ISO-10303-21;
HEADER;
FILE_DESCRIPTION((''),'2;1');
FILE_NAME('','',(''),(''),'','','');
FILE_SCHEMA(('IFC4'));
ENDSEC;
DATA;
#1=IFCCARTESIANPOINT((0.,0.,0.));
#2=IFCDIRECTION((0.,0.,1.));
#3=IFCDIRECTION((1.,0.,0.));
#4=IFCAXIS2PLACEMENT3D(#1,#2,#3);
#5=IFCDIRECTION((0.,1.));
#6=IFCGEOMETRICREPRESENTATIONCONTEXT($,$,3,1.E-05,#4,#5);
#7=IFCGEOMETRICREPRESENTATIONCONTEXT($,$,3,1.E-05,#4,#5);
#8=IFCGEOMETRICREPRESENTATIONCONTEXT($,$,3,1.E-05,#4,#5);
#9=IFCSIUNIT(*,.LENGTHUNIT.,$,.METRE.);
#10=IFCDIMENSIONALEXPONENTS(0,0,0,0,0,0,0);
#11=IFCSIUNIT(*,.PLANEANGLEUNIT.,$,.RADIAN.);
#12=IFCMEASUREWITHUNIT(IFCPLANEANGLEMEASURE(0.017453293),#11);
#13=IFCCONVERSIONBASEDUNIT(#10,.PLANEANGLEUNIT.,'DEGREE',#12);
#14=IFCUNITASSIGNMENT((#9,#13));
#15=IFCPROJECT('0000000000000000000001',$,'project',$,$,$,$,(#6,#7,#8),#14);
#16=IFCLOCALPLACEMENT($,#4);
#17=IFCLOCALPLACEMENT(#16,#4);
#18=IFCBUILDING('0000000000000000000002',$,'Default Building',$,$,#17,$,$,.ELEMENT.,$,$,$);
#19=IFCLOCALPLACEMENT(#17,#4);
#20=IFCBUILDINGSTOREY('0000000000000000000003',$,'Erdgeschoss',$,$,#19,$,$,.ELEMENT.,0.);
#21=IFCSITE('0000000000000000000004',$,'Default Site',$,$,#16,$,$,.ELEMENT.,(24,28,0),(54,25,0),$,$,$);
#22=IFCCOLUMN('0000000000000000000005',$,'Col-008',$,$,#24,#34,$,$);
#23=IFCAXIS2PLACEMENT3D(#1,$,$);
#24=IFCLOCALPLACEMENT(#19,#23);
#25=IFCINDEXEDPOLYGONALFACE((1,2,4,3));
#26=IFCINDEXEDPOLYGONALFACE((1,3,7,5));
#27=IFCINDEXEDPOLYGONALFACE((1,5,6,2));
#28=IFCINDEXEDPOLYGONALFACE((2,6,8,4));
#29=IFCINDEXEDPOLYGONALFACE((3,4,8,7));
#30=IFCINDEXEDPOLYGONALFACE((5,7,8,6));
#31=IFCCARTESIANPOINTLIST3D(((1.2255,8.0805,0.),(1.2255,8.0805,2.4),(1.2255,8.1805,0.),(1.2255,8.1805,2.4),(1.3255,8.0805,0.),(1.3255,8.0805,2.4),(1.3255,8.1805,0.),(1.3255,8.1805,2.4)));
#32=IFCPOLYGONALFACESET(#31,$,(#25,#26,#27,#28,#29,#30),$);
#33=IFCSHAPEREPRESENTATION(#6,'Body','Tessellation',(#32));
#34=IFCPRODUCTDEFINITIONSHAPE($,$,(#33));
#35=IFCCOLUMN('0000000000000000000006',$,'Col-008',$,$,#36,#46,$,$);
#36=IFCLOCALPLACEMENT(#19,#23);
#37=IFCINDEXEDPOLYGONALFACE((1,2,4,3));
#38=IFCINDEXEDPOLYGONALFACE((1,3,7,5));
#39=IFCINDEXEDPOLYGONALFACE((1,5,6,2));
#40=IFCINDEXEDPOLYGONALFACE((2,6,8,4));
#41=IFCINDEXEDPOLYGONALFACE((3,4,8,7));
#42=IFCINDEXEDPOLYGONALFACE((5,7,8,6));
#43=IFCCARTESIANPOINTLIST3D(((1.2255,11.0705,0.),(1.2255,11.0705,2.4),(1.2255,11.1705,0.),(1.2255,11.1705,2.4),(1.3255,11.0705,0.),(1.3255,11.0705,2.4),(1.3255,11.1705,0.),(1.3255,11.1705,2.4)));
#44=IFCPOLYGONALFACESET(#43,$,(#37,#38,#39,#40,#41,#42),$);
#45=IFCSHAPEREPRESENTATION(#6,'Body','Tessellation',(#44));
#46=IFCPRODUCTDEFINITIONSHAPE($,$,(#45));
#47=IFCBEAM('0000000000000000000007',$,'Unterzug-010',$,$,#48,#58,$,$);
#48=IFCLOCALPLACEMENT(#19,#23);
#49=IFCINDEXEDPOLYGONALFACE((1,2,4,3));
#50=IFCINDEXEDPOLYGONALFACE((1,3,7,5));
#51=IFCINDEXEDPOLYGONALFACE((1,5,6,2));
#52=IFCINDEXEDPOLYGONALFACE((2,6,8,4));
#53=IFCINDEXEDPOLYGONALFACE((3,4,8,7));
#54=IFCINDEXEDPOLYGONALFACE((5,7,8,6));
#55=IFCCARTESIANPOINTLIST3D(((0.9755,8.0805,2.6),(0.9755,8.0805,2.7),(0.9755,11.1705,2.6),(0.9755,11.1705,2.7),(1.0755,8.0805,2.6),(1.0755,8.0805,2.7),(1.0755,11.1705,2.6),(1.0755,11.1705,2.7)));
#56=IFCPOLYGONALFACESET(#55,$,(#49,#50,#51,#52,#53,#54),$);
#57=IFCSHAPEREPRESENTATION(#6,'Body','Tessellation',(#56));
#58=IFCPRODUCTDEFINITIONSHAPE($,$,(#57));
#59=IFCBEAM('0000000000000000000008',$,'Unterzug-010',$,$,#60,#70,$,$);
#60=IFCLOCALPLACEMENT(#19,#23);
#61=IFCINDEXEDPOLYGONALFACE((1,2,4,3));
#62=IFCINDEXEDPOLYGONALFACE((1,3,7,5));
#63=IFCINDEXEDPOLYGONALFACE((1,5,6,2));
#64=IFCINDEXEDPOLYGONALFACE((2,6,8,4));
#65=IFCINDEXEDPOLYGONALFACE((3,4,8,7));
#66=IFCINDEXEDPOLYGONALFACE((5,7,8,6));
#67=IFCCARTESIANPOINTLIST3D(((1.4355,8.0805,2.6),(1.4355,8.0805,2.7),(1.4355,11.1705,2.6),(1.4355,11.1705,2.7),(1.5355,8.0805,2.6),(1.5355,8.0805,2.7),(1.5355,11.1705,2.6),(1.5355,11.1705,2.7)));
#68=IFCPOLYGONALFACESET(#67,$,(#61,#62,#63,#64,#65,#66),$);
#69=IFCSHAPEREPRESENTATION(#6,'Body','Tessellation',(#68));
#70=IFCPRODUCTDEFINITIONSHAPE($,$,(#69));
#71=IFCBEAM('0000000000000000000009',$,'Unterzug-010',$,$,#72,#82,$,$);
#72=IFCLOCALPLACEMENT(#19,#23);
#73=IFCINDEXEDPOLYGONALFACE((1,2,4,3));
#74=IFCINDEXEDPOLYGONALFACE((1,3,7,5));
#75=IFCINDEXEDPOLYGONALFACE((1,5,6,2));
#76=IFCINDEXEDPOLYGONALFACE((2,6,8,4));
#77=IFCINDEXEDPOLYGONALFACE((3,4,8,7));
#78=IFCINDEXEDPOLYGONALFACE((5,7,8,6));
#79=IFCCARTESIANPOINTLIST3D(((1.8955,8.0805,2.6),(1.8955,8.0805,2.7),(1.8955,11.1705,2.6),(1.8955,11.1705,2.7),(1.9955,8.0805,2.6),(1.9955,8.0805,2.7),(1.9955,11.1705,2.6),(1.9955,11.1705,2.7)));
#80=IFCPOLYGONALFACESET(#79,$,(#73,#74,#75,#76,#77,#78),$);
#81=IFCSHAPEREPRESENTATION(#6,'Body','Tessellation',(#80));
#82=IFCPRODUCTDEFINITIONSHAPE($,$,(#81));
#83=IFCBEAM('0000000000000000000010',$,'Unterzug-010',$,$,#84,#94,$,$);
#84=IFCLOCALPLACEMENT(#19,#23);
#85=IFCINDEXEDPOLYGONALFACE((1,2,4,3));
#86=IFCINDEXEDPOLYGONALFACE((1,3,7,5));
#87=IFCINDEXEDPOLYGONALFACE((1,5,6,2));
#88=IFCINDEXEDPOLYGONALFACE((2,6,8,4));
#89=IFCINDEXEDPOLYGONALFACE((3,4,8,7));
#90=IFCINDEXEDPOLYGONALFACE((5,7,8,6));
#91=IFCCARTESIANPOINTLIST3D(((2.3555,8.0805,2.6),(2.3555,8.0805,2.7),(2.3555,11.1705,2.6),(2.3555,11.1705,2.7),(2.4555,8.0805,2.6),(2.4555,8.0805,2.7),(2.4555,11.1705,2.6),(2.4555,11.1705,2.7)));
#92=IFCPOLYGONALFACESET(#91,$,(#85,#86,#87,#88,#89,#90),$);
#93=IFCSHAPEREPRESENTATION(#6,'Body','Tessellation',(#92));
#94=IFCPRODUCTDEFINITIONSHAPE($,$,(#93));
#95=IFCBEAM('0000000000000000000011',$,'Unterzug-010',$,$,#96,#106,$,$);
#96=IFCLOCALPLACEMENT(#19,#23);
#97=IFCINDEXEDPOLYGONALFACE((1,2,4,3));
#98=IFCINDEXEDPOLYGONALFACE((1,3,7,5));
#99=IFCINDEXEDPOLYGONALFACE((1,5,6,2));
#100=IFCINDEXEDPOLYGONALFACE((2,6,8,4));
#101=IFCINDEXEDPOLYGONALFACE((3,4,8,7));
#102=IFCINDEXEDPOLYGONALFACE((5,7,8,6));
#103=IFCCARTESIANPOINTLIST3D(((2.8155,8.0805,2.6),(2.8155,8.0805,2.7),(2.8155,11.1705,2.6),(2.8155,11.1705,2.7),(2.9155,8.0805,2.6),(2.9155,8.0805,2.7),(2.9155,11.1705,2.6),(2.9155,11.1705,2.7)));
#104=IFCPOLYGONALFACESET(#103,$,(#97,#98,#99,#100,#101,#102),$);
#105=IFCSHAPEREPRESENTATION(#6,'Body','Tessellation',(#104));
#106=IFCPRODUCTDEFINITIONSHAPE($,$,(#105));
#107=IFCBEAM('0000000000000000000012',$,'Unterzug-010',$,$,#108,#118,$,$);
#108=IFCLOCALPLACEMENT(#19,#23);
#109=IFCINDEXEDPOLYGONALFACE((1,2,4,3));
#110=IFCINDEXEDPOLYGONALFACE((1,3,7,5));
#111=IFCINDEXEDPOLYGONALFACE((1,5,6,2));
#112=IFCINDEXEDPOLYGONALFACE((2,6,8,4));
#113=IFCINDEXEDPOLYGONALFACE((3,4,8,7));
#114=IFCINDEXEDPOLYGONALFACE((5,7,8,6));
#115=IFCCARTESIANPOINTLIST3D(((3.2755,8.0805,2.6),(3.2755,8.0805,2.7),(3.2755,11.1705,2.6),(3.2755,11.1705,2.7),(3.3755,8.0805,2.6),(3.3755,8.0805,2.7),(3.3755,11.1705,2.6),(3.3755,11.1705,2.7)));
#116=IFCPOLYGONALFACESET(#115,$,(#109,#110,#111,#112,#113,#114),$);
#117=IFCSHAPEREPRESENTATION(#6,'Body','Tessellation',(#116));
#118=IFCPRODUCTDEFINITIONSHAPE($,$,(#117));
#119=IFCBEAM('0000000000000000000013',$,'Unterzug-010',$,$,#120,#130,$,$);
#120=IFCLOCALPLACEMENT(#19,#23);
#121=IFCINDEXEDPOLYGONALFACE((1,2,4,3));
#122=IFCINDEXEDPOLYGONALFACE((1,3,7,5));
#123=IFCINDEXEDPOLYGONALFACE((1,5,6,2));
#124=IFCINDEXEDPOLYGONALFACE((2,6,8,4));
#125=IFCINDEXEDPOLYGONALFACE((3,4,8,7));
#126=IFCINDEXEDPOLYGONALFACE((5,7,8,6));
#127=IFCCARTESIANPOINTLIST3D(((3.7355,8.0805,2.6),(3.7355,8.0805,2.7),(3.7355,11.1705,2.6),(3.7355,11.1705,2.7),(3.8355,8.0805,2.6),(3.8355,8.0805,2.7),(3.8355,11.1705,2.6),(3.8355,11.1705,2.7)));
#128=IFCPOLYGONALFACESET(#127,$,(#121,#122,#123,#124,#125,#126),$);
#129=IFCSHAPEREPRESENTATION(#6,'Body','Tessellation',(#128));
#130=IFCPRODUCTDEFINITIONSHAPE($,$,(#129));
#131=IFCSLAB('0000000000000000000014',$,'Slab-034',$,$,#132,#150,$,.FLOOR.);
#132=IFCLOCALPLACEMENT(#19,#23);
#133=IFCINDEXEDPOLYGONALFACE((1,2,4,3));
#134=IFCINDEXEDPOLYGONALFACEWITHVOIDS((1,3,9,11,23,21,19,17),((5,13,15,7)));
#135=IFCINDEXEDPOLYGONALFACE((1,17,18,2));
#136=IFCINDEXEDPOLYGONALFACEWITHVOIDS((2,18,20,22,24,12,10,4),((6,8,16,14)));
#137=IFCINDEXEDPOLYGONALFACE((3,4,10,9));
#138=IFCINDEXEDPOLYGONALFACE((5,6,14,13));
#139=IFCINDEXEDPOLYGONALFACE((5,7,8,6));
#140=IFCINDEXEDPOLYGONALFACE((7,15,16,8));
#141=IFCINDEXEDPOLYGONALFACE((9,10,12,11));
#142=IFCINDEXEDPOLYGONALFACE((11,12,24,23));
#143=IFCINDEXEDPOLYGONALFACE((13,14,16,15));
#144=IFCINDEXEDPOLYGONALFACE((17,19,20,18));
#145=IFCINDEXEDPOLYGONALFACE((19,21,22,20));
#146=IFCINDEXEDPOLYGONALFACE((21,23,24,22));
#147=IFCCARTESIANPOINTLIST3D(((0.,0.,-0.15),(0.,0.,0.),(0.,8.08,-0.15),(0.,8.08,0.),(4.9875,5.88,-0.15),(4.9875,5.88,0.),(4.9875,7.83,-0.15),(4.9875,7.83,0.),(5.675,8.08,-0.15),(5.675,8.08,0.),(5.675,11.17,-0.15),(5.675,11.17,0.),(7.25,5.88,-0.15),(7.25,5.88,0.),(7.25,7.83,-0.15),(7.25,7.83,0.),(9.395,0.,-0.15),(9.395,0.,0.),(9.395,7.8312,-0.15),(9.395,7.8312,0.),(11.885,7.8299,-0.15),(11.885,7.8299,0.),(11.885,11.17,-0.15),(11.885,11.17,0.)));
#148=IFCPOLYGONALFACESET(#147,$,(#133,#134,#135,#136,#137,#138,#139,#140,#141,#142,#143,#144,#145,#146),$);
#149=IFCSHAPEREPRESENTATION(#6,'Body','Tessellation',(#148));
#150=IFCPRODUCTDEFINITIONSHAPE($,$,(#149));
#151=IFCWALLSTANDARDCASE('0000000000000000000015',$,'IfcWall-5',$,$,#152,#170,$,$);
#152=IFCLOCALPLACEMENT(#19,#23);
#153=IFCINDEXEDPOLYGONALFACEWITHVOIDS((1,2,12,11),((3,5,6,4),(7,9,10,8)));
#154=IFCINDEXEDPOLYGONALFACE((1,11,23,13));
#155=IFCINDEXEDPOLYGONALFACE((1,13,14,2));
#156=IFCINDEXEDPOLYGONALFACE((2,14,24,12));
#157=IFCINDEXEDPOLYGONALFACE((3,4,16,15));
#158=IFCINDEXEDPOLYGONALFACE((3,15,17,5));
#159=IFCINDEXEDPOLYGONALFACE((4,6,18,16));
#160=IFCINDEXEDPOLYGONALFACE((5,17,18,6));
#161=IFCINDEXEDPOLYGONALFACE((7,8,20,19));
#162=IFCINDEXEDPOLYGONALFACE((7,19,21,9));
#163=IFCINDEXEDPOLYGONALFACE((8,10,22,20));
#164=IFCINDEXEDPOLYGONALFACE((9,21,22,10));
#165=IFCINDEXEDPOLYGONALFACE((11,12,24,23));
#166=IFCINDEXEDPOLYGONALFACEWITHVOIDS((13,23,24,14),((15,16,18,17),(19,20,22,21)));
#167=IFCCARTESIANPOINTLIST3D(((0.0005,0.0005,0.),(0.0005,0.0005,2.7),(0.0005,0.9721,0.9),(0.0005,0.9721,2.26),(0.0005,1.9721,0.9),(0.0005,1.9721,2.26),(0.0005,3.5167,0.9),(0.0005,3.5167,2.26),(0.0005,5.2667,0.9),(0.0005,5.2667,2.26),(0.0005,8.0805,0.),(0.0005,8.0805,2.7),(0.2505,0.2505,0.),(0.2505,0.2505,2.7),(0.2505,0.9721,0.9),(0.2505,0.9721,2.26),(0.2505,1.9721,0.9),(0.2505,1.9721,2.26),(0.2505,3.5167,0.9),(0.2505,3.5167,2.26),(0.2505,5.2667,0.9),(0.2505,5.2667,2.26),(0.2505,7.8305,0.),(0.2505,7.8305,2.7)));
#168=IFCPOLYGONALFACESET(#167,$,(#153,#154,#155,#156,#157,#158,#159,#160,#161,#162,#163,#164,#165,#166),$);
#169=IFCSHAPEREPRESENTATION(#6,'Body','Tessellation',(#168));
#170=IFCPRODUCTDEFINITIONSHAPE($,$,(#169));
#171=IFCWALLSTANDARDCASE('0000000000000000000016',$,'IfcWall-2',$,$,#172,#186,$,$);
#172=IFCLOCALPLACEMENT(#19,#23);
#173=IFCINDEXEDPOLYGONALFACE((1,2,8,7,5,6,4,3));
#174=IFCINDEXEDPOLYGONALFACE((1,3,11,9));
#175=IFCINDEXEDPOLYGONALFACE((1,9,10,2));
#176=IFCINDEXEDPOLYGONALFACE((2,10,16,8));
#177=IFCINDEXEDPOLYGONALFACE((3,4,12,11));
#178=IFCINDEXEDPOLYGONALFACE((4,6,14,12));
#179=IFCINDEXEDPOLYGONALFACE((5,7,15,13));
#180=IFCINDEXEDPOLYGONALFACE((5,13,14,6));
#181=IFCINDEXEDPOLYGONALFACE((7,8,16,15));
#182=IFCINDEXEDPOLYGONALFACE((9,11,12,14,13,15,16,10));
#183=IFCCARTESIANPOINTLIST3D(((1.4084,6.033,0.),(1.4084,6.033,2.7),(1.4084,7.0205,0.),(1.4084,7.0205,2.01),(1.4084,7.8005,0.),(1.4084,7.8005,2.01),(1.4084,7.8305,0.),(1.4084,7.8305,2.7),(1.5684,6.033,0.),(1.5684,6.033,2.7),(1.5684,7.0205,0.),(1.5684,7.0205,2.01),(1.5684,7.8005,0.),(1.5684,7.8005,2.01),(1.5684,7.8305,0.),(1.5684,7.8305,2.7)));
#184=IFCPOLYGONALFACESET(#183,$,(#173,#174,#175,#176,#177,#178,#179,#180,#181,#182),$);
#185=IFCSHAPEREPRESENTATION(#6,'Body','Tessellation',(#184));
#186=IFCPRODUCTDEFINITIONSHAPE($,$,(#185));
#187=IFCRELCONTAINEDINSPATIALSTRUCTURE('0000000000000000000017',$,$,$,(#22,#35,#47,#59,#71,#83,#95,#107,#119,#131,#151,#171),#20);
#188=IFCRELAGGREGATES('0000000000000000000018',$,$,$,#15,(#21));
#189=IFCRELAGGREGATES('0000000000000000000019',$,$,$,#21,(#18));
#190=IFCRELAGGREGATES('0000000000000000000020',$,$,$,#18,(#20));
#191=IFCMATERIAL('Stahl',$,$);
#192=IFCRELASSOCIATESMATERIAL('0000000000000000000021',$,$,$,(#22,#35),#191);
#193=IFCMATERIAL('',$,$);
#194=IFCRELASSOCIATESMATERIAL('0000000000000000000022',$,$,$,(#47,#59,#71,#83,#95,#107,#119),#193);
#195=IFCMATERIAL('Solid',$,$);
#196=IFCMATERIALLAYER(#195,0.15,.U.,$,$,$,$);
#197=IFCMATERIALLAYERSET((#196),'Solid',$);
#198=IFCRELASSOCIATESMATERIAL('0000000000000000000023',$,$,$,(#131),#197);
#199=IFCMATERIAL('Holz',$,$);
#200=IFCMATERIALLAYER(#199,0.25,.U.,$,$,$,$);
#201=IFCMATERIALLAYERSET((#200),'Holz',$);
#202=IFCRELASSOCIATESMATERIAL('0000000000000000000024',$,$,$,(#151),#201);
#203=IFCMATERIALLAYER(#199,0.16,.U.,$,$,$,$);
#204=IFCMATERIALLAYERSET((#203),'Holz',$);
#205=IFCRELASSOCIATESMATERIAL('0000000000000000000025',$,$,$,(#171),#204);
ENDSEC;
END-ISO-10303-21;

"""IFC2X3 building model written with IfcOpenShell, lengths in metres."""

from ifc_helpers import new_model, entity, si_unit, converted_unit, direction, frame, frame_2d, origin_with_axes, place, context, project, spatial, polyline, rectangle, outline, extrude, material, layer, layer_set, layer_usage, element, save


model = new_model("IFC2X3")

# Units and contexts
context_of_model_1 = context(None, 3, precision=1e-05, world=origin_with_axes(), true_north=direction((0.0, 1.0)))
context_of_model_2 = context(None, 3, precision=1e-05, world=origin_with_axes(), true_north=direction((0.0, 1.0)))
context_of_model_3 = context(None, 3, precision=1e-05, world=origin_with_axes(), true_north=direction((0.0, 1.0)))
ifc_project = project(units=[si_unit("LENGTHUNIT", "METRE"), converted_unit("PLANEANGLEUNIT", "DEGREE", entity("IfcPlaneAngleMeasure", 0.017453293), si_unit("PLANEANGLEUNIT", "RADIAN"), dimensions=[0, 0, 0, 0, 0, 0, 0])], contexts=[context_of_model_1, context_of_model_2, context_of_model_3])

# Site, building, storey
site_placement = place(None, origin_with_axes())
site = spatial("IfcSite", under=ifc_project, at=site_placement, Name="Default Site", CompositionType="ELEMENT", RefLatitude=(24, 28, 0), RefLongitude=(54, 25, 0))
building_placement = place(site_placement, origin_with_axes())
building = spatial("IfcBuilding", under=site, at=building_placement, Name="Default Building", CompositionType="ELEMENT")
storey_placement = place(building_placement, origin_with_axes())
storey = spatial("IfcBuildingStorey", under=building, at=storey_placement, Name="Erdgeschoss", CompositionType="ELEMENT", Elevation=0.0)

# Columns
ifc_material_1 = material(Name="Stahl")
for number, where, z_axis, x_axis, name in (
    (1, (1.2755, 8.1305, 0.0), (0.0, 0.0, 1.0), (1.0, 0.0, 0.0), "Col-008"),
    (2, (1.2755, 11.1205, 0.0), (0.0, 0.0, 1.0), (1.0, 0.0, 0.0), "Col-008"),
):
    element("IfcColumn", number, at=place(storey_placement, frame(where, z_axis=z_axis, x_axis=x_axis)), inside=storey, material=ifc_material_1, Name=name, context=context_of_model_1, shape_type="SweptSolid", body=[
        extrude(outline(polyline([(-0.05, -0.05), (0.05, -0.05), (0.05, 0.05), (-0.05, 0.05), (-0.05, -0.05)])), origin_with_axes(), (0.0, 0.0, 1.0), 2.4),
    ])

# Beams
ifc_material_2 = material(Name="")
for number, where, z_axis, x_axis, name in (
    (3, (1.0255, 8.0805, 2.7), (0.0, 0.0, 1.0), (1.0, 0.0, 0.0), "Unterzug-010"),
    (4, (1.4855, 8.0805, 2.7), (0.0, 0.0, 1.0), (1.0, 0.0, 0.0), "Unterzug-010"),
    (5, (1.9455, 8.0805, 2.7), (0.0, 0.0, 1.0), (1.0, 0.0, 0.0), "Unterzug-010"),
    (6, (2.4055, 8.0805, 2.7), (0.0, 0.0, 1.0), (1.0, 0.0, 0.0), "Unterzug-010"),
    (7, (2.8655, 8.0805, 2.7), (0.0, 0.0, 1.0), (1.0, 0.0, 0.0), "Unterzug-010"),
    (8, (3.3255, 8.0805, 2.7), (0.0, 0.0, 1.0), (1.0, 0.0, 0.0), "Unterzug-010"),
    (9, (3.7855, 8.0805, 2.7), (0.0, 0.0, 1.0), (1.0, 0.0, 0.0), "Unterzug-010"),
):
    element("IfcBeam", number, at=place(storey_placement, frame(where, z_axis=z_axis, x_axis=x_axis)), inside=storey, material=ifc_material_2, Name=name, context=context_of_model_1, shape_type="SweptSolid", body=[
        extrude(outline(polyline([(-0.1, -0.05), (0.0, -0.05), (0.0, 0.05), (-0.1, 0.05), (-0.1, -0.05)])), frame((0.0, 0.0, 0.0), z_axis=(0.0, 1.0, 0.0), x_axis=(0.0, 0.0, 1.0)), (0.0, 0.0, 1.0), 3.09),
    ])

# Slab, opening
ifc_material_3 = material(Name="Solid")
ifc_layer_1 = layer(ifc_material_3, 0.15, ventilated="UNKNOWN")
ifc_layer_set_1 = layer_set([ifc_layer_1], Name="Solid")
ifc_layer_usage_1 = layer_usage(ifc_layer_set_1, "AXIS3", "NEGATIVE", 0.15)
slab_placement = place(storey_placement, frame((0.0, 0.0, -0.15), z_axis=(0.0, 0.0, 1.0), x_axis=(0.0, 1.0, 0.0)))
slab = element("IfcSlab", 10, at=slab_placement, inside=storey, material=ifc_layer_usage_1, Name="Slab-034", PredefinedType="FLOOR", context=context_of_model_1, shape_type="SweptSolid", body=[
    extrude(outline(polyline([(0.0, 0.0), (8.08, 0.0), (8.08, -5.675), (11.17, -5.675), (11.17, -11.885), (7.8299, -11.885), (7.8312, -9.395), (0.0, -9.395), (0.0, 0.0)])), origin_with_axes(), (0.0, 0.0, 1.0), 0.15),
])
opening_1_placement = place(slab_placement, origin_with_axes())
element("IfcOpeningElement", 11, at=opening_1_placement, cuts=slab, context=context_of_model_1, shape_type="SweptSolid", body=[
    extrude(outline(polyline([(7.83, -4.9875), (7.83, -7.25), (5.88, -7.25), (5.88, -4.9875), (7.83, -4.9875)])), origin_with_axes(), (0.0, 0.0, 1.0), 0.15),
])

# Wall, openings
ifc_material_4 = material(Name="Holz")
ifc_layer_2 = layer(ifc_material_4, 0.25, ventilated="UNKNOWN")
ifc_layer_set_2 = layer_set([ifc_layer_2], Name="Holz")
ifc_layer_usage_2 = layer_usage(ifc_layer_set_2, "AXIS2", "NEGATIVE", 0.0)
wall_1_placement = place(storey_placement, frame((0.0005, 0.0005, 0.0), z_axis=(0.0, 0.0, 1.0), x_axis=(0.0, 1.0, 0.0)))
wall_1 = element("IfcWallStandardCase", 12, at=wall_1_placement, inside=storey, material=ifc_layer_usage_2, Name="IfcWall-5", context=context_of_model_1, shape_type="SweptSolid", body=[
    extrude(outline(polyline([(0.25, -0.25), (7.83, -0.25), (8.08, 0.0), (0.0, 0.0), (0.25, -0.25)])), origin_with_axes(), (0.0, 0.0, 1.0), 2.7),
])
opening_2_placement = place(wall_1_placement, frame((1.4716, -0.25, 0.9), z_axis=(0.0, 0.0, 1.0), x_axis=(1.0, 0.0, 0.0)))
element("IfcOpeningElement", 13, at=opening_2_placement, cuts=wall_1, context=context_of_model_1, shape_type="SweptSolid", body=[
    extrude(rectangle(XDim=1.36, YDim=1.0, at=frame_2d((0.0, 0.68), x_axis=(0.0, -1.0))), frame((0.0, 0.0, 0.0), z_axis=(0.0, 1.0, 0.0), x_axis=(-1.0, 0.0, 0.0)), (0.0, 0.0, 1.0), 0.25),
])
opening_3_placement = place(wall_1_placement, frame((4.3912, -0.25, 0.9), z_axis=(0.0, 0.0, 1.0), x_axis=(1.0, 0.0, 0.0)))
element("IfcOpeningElement", 14, at=opening_3_placement, cuts=wall_1, context=context_of_model_1, shape_type="SweptSolid", body=[
    extrude(rectangle(XDim=1.36, YDim=1.75, at=frame_2d((0.0, 0.68), x_axis=(0.0, -1.0))), frame((0.0, 0.0, 0.0), z_axis=(0.0, 1.0, 0.0), x_axis=(-1.0, 0.0, 0.0)), (0.0, 0.0, 1.0), 0.25),
])

# Wall, opening
ifc_layer_3 = layer(ifc_material_4, 0.16, ventilated="UNKNOWN")
ifc_layer_set_3 = layer_set([ifc_layer_3], Name="Holz")
ifc_layer_usage_3 = layer_usage(ifc_layer_set_3, "AXIS2", "NEGATIVE", 0.0)
wall_2_placement = place(storey_placement, frame((1.4084, 6.033, 0.0), z_axis=(0.0, 0.0, 1.0), x_axis=(0.0, 1.0, 0.0)))
wall_2 = element("IfcWallStandardCase", 15, at=wall_2_placement, inside=storey, material=ifc_layer_usage_3, Name="IfcWall-2", context=context_of_model_1, shape_type="SweptSolid", body=[
    extrude(outline(polyline([(0.0, -0.16), (1.7975, -0.16), (1.7975, 0.0), (0.0, 0.0), (0.0, -0.16)])), origin_with_axes(), (0.0, 0.0, 1.0), 2.7),
])
opening_4_placement = place(wall_2_placement, frame((1.3775, -0.16, 0.0), z_axis=(0.0, 0.0, 1.0), x_axis=(1.0, 0.0, 0.0)))
element("IfcOpeningElement", 16, at=opening_4_placement, cuts=wall_2, context=context_of_model_1, shape_type="SweptSolid", body=[
    extrude(rectangle(XDim=2.01, YDim=0.78, at=frame_2d((0.0, 1.005), x_axis=(0.0, -1.0))), frame((0.0, 0.0, 0.0), z_axis=(0.0, 1.0, 0.0), x_axis=(-1.0, 0.0, 0.0)), (0.0, 0.0, 1.0), 0.16),
])

save(model, "model.ifc")
